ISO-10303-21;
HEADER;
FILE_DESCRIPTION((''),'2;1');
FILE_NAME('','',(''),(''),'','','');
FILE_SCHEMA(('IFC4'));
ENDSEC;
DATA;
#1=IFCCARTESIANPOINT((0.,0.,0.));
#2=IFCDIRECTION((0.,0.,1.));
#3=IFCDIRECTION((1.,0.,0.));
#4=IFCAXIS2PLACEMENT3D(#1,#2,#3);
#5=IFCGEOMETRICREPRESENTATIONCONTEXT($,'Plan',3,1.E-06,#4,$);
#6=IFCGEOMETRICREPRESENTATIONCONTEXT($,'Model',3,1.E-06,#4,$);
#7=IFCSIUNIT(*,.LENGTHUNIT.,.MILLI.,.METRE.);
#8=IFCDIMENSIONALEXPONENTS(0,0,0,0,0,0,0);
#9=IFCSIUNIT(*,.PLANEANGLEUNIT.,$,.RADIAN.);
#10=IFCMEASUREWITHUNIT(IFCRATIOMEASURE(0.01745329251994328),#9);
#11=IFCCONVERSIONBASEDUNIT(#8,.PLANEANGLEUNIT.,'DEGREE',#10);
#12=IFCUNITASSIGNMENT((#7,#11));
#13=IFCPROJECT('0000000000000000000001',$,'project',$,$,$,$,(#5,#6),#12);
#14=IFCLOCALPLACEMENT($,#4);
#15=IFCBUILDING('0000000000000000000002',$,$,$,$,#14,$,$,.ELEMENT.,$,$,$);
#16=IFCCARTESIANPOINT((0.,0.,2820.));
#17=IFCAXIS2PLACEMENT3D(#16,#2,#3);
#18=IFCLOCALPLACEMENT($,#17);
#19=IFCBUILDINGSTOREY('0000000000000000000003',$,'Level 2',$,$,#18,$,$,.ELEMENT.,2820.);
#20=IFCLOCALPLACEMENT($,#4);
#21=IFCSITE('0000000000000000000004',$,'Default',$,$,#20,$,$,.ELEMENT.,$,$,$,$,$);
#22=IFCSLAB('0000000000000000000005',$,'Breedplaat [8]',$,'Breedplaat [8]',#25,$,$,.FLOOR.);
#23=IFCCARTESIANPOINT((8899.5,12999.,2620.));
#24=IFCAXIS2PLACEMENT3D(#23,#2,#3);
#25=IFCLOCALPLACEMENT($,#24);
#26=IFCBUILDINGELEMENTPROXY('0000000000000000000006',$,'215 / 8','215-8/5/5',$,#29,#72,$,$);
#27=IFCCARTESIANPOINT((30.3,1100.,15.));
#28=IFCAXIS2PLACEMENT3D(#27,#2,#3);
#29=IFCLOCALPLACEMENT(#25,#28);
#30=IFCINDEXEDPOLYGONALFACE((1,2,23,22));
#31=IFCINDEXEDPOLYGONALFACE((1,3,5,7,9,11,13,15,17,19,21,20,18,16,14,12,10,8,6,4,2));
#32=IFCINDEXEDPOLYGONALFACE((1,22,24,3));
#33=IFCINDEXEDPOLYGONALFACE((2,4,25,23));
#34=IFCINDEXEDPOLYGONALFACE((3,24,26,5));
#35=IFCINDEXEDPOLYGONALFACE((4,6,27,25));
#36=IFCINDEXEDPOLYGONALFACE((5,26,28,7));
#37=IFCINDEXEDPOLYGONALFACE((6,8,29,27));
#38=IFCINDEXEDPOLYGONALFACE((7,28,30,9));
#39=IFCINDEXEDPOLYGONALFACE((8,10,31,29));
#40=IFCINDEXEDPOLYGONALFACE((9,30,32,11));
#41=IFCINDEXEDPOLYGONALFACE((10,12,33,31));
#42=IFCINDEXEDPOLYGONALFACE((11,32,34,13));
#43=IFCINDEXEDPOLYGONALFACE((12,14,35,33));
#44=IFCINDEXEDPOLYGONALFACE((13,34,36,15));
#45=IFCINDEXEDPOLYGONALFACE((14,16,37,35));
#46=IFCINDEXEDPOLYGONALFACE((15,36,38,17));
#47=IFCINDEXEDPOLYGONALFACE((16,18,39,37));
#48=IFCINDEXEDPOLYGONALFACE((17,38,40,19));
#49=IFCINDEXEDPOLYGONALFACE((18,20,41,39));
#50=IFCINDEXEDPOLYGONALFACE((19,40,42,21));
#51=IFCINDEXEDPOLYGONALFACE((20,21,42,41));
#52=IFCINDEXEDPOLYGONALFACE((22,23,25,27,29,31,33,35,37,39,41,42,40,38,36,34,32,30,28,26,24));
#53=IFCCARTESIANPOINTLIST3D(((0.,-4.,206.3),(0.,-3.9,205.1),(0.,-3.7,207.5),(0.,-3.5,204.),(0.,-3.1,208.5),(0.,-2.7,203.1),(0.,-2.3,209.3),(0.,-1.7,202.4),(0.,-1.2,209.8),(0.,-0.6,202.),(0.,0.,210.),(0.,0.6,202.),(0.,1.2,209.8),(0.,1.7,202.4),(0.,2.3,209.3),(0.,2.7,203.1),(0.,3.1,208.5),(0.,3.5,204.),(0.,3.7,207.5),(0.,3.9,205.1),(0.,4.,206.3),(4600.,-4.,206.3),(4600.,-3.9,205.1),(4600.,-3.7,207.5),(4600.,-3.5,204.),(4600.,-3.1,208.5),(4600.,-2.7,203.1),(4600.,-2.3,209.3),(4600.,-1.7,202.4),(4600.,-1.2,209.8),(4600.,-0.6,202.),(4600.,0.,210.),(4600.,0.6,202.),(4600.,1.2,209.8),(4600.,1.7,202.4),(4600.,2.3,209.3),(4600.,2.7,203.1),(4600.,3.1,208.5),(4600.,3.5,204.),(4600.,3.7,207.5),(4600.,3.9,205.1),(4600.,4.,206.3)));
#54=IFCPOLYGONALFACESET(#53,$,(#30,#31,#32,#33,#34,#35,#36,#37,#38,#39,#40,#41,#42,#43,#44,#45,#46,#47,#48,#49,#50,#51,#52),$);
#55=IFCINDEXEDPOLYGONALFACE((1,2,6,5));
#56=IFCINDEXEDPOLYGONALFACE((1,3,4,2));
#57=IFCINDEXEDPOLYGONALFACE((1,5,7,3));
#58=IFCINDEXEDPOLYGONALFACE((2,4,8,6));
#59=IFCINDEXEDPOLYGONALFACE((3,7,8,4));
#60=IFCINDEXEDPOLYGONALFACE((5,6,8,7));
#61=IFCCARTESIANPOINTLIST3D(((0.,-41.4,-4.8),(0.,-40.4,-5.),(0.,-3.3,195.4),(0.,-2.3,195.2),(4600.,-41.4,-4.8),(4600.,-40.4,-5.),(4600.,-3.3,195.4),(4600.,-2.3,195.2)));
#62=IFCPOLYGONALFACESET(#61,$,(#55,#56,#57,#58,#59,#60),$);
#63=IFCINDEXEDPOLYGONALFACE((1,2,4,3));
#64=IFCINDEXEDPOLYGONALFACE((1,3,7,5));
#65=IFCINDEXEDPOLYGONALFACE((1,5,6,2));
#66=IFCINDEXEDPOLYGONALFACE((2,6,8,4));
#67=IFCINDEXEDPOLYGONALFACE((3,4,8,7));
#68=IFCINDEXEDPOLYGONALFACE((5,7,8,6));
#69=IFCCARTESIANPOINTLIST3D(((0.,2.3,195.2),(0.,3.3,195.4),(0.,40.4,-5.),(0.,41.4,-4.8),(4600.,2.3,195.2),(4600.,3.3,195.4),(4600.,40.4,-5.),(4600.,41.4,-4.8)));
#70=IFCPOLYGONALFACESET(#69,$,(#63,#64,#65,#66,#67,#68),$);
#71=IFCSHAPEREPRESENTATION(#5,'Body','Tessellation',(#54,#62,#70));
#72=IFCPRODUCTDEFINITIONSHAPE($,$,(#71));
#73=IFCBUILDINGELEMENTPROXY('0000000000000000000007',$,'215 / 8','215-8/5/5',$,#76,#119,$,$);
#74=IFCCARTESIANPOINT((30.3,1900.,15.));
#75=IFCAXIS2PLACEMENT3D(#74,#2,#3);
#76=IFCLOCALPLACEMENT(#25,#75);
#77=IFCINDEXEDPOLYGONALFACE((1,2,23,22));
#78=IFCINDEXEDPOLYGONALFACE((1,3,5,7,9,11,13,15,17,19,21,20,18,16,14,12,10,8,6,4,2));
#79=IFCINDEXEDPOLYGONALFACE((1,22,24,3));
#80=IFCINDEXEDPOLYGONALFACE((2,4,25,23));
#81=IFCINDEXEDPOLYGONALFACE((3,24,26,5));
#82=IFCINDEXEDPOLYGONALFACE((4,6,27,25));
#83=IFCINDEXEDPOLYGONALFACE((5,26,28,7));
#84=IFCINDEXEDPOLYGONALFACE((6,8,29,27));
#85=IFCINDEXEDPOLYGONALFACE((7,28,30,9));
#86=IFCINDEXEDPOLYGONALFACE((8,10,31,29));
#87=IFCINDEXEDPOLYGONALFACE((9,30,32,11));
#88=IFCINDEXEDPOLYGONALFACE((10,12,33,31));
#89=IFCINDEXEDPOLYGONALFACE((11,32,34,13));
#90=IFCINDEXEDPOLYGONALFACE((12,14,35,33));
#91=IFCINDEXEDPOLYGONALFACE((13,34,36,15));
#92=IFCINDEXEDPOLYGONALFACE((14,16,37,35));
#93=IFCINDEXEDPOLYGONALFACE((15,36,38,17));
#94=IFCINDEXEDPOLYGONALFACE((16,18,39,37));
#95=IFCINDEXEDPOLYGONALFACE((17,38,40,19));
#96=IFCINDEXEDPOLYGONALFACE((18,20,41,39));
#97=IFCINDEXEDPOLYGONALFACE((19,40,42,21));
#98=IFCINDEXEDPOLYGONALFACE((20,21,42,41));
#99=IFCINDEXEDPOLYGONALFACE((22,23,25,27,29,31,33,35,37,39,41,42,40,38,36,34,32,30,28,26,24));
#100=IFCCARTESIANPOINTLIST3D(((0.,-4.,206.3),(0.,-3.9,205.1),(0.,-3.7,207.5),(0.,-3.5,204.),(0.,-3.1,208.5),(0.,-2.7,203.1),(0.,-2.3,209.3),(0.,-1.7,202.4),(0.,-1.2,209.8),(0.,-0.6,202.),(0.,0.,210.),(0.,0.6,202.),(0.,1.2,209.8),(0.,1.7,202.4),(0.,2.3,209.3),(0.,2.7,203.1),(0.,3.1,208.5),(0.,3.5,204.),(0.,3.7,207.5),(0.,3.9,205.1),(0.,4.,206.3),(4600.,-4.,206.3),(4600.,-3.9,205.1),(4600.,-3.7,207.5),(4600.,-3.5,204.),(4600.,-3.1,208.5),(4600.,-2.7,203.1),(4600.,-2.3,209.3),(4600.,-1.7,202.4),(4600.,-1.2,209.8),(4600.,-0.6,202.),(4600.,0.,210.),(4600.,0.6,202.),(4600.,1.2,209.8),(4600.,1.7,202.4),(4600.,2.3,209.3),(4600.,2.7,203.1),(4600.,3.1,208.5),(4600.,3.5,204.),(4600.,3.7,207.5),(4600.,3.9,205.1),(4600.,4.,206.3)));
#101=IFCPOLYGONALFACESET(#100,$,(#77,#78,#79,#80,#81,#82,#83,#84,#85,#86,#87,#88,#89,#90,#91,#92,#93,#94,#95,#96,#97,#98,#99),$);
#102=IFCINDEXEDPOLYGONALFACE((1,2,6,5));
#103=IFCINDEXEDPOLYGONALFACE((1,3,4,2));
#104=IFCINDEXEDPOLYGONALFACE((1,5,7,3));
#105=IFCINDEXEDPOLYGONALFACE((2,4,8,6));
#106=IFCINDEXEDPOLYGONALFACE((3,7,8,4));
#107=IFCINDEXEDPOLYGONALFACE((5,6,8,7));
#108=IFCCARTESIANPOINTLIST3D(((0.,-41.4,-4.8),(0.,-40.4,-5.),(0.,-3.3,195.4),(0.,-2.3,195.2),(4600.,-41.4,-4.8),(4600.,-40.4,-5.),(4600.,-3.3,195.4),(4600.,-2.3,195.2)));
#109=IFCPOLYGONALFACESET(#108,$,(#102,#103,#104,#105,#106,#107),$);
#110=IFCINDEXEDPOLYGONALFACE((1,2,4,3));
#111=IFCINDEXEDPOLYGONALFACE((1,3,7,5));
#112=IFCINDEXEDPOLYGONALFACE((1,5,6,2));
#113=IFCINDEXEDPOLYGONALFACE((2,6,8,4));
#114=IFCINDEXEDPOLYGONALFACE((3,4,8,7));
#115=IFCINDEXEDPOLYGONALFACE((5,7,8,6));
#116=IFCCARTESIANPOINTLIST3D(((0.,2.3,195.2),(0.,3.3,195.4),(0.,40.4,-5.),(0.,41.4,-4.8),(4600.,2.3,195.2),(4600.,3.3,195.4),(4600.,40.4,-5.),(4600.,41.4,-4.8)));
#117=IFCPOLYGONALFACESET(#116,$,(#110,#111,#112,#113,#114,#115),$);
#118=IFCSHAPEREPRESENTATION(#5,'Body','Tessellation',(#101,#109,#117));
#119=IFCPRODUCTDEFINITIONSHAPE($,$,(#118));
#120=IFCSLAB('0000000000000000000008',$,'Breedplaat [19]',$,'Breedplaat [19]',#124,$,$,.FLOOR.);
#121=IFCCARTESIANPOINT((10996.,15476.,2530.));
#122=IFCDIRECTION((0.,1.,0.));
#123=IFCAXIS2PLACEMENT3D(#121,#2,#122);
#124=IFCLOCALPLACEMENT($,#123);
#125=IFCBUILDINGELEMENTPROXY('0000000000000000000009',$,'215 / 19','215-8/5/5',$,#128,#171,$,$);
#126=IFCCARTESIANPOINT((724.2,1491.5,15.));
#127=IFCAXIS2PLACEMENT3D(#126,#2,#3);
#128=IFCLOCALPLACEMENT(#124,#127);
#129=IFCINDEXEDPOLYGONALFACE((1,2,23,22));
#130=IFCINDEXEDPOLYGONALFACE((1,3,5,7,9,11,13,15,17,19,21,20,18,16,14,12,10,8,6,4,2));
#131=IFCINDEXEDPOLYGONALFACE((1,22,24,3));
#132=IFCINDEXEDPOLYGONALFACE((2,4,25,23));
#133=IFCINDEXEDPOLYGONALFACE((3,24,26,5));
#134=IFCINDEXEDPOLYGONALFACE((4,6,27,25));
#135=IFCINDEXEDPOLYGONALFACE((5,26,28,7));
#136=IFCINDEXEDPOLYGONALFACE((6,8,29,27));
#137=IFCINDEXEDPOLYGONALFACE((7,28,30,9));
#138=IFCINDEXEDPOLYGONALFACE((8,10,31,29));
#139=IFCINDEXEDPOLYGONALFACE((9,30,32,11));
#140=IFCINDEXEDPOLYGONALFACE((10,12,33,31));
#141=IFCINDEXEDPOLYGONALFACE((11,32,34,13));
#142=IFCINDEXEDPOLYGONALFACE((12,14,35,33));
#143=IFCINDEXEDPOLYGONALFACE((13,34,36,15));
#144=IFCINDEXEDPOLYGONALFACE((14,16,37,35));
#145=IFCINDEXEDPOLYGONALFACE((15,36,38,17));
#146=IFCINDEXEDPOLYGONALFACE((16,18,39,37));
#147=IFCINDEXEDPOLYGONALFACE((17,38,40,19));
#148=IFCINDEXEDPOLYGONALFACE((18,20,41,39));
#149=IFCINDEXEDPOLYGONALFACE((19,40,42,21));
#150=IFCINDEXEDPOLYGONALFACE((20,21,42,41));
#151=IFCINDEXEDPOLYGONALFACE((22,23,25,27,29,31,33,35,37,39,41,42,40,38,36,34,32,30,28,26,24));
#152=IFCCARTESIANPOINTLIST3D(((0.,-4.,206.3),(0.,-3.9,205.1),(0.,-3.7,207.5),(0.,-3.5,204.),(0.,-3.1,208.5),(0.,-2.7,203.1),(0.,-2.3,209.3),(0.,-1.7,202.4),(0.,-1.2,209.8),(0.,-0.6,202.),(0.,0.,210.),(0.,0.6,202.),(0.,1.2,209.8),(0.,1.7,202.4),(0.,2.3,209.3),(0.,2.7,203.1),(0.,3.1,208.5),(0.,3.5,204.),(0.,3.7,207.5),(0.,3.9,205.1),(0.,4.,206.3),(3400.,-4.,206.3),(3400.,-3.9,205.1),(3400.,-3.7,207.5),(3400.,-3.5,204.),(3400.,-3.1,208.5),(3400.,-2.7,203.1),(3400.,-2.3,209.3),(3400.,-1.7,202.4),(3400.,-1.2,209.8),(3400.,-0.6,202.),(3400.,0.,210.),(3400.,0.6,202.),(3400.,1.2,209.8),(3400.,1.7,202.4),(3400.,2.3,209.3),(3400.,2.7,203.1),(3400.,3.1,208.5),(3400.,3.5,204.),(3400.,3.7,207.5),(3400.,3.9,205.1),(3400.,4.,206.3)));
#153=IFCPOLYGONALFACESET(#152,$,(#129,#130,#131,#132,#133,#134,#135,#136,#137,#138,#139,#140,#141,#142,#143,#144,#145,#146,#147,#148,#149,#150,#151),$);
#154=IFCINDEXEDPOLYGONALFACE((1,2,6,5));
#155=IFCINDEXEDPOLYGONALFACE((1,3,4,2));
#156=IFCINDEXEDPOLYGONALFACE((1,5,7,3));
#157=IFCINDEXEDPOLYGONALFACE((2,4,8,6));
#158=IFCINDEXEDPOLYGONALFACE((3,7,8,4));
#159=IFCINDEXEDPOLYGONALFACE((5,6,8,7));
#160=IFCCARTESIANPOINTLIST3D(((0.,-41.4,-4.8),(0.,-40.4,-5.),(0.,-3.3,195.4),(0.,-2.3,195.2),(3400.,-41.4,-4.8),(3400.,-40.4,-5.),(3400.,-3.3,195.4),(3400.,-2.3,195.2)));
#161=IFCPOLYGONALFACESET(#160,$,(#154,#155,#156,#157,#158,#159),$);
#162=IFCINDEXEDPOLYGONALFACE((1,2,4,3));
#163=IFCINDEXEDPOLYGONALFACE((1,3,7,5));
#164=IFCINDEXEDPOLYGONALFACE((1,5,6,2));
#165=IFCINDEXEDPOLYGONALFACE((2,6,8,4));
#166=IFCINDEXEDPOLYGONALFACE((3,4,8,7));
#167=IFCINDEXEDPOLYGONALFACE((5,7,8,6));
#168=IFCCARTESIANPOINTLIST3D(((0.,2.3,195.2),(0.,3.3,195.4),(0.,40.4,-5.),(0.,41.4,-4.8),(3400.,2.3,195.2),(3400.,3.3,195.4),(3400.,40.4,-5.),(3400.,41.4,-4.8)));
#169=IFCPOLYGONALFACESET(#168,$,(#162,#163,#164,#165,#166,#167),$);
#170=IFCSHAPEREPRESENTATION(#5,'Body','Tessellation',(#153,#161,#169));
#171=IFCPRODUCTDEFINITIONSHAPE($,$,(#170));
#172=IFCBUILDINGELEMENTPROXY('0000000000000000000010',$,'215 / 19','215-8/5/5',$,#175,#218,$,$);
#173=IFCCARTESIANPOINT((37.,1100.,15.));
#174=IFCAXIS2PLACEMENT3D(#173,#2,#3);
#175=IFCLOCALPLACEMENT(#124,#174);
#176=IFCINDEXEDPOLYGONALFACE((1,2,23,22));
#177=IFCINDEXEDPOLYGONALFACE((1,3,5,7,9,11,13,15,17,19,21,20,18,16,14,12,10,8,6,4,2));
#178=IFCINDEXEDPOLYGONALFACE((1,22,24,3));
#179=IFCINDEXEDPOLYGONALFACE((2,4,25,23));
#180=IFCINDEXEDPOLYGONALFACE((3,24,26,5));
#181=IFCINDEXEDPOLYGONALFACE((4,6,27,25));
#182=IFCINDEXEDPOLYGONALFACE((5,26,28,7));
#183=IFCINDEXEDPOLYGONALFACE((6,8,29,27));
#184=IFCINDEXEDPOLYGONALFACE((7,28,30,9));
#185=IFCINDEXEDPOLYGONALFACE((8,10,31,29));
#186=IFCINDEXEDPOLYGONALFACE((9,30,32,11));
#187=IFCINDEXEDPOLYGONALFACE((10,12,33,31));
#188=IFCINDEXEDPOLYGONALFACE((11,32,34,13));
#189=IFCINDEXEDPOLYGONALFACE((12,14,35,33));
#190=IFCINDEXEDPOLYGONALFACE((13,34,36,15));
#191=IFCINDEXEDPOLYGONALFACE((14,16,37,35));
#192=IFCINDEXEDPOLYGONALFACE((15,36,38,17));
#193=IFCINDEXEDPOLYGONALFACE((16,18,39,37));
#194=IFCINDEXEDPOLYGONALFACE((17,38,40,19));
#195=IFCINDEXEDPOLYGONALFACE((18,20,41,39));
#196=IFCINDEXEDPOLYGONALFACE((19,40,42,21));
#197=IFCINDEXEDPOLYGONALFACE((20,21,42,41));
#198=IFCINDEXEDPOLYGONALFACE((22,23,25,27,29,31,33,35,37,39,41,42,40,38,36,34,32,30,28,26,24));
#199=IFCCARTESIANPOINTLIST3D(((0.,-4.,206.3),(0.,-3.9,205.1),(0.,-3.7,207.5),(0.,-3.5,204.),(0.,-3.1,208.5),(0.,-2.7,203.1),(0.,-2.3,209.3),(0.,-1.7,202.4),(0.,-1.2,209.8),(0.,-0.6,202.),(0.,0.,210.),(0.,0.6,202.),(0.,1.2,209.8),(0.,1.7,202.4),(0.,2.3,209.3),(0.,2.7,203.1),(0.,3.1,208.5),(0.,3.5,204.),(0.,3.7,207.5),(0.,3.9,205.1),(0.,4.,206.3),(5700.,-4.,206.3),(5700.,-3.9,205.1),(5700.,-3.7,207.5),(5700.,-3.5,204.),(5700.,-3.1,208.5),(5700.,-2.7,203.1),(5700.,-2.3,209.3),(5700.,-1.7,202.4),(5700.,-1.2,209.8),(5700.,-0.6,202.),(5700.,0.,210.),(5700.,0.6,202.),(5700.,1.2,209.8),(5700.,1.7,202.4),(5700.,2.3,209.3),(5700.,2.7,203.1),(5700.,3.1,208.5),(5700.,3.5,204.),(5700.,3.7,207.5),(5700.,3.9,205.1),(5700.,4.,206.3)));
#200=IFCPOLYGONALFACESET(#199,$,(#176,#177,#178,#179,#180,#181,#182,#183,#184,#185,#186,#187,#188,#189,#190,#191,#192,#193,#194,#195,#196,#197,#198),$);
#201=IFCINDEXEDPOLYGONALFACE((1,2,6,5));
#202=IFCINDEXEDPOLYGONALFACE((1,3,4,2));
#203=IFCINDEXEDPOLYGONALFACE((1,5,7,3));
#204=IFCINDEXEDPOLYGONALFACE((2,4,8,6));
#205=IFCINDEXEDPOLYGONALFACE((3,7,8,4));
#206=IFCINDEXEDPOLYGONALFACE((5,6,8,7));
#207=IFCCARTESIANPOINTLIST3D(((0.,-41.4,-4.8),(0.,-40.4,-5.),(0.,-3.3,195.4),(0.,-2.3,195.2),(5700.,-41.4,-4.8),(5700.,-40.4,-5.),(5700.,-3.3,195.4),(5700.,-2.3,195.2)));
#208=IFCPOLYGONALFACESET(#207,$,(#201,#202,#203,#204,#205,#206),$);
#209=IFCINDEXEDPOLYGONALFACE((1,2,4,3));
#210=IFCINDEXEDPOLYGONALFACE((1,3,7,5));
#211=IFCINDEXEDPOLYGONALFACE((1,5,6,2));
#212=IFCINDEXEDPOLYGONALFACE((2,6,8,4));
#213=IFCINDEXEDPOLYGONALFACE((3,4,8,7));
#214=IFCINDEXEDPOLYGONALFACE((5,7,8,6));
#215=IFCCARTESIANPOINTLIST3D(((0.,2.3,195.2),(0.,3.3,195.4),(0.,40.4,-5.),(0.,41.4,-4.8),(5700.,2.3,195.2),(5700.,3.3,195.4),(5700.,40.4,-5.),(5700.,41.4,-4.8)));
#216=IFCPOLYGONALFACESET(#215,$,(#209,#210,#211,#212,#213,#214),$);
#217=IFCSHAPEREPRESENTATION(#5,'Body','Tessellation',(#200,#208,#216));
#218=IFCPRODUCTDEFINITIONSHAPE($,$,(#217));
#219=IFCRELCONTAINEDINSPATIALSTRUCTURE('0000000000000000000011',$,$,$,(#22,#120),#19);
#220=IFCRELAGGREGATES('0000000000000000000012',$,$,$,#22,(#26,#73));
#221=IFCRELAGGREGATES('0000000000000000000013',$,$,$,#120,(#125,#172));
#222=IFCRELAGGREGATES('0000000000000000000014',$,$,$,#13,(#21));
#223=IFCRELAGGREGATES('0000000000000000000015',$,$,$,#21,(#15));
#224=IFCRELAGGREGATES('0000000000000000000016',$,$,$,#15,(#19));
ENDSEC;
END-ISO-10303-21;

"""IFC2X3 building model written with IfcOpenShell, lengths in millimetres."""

from ifc_helpers import new_model, entity, si_unit, converted_unit, frame, origin_with_axes, origin_2d_with_axis, place, context, project, spatial, rectangle, circle, extrude, element, aggregate, save


model = new_model("IFC2X3")

# Units and contexts
plan_context = context("Plan", 3, precision=1e-06, world=origin_with_axes())
model_context = context("Model", 3, precision=1e-06, world=origin_with_axes())
ifc_project = project(units=[si_unit("LENGTHUNIT", "METRE", prefix="MILLI"), converted_unit("PLANEANGLEUNIT", "DEGREE", entity("IfcRatioMeasure", 0.01745329251994328), si_unit("PLANEANGLEUNIT", "RADIAN"), dimensions=[0, 0, 0, 0, 0, 0, 0])], contexts=[plan_context, model_context])

# Site, building, storey
site_placement = place(None, origin_with_axes())
site = spatial("IfcSite", under=ifc_project, at=site_placement, Name="Default", CompositionType="ELEMENT")
building_placement = place(None, origin_with_axes())
building = spatial("IfcBuilding", under=site, at=building_placement, CompositionType="ELEMENT")
storey_placement = place(None, frame((0.0, 0.0, 2820.0), z_axis=(0.0, 0.0, 1.0), x_axis=(1.0, 0.0, 0.0)))
storey = spatial("IfcBuildingStorey", under=building, at=storey_placement, Name="Level 2", CompositionType="ELEMENT", Elevation=2820.0)

# Slabs, building element proxies
slab_1_placement = place(None, frame((8899.5, 12999.0, 2620.0), z_axis=(0.0, 0.0, 1.0), x_axis=(1.0, 0.0, 0.0)))
slab_1 = element("IfcSlab", 1, at=slab_1_placement, inside=storey, Name="Breedplaat [8]", ObjectType="Breedplaat [8]", PredefinedType="FLOOR")
proxy_1_placement = place(slab_1_placement, frame((30.3, 1100.0, 15.0), z_axis=(0.0, 0.0, 1.0), x_axis=(1.0, 0.0, 0.0)))
proxy_1 = element("IfcBuildingElementProxy", 2, at=proxy_1_placement, Name="215 / 8", Description="215-8/5/5", context=plan_context, shape_type="SweptSolid", body=[
    extrude(circle(Radius=4.0, at=origin_2d_with_axis()), frame((0.0, 0.0, 206.0), z_axis=(1.0, 0.0, 0.0), x_axis=(0.0, 0.0, 1.0)), (0.0, 0.0, 1.0), 4600.0),
    extrude(rectangle(XDim=203.8, YDim=1.0, at=origin_2d_with_axis()), frame((0.0, -21.9, 95.2), z_axis=(1.0, 0.0, 0.0), x_axis=(0.0, 0.187112, 0.982339)), (0.0, 0.0, 1.0), 4600.0),
    extrude(rectangle(XDim=203.8, YDim=1.0, at=origin_2d_with_axis()), frame((0.0, 21.9, 95.2), z_axis=(1.0, 0.0, 0.0), x_axis=(0.0, -0.187112, 0.982339)), (0.0, 0.0, 1.0), 4600.0),
])
proxy_2_placement = place(slab_1_placement, frame((30.3, 1900.0, 15.0), z_axis=(0.0, 0.0, 1.0), x_axis=(1.0, 0.0, 0.0)))
proxy_2 = element("IfcBuildingElementProxy", 3, at=proxy_2_placement, Name="215 / 8", Description="215-8/5/5", context=plan_context, shape_type="SweptSolid", body=[
    extrude(circle(Radius=4.0, at=origin_2d_with_axis()), frame((0.0, 0.0, 206.0), z_axis=(1.0, 0.0, 0.0), x_axis=(0.0, 0.0, 1.0)), (0.0, 0.0, 1.0), 4600.0),
    extrude(rectangle(XDim=203.8, YDim=1.0, at=origin_2d_with_axis()), frame((0.0, -21.9, 95.2), z_axis=(1.0, 0.0, 0.0), x_axis=(0.0, 0.187112, 0.982339)), (0.0, 0.0, 1.0), 4600.0),
    extrude(rectangle(XDim=203.8, YDim=1.0, at=origin_2d_with_axis()), frame((0.0, 21.9, 95.2), z_axis=(1.0, 0.0, 0.0), x_axis=(0.0, -0.187112, 0.982339)), (0.0, 0.0, 1.0), 4600.0),
])
aggregate(slab_1, [proxy_1, proxy_2])
slab_2_placement = place(None, frame((10996.0, 15476.0, 2530.0), z_axis=(0.0, 0.0, 1.0), x_axis=(0.0, 1.0, 0.0)))
slab_2 = element("IfcSlab", 4, at=slab_2_placement, inside=storey, Name="Breedplaat [19]", ObjectType="Breedplaat [19]", PredefinedType="FLOOR")
proxy_3_placement = place(slab_2_placement, frame((724.2, 1491.5, 15.0), z_axis=(0.0, 0.0, 1.0), x_axis=(1.0, 0.0, 0.0)))
proxy_3 = element("IfcBuildingElementProxy", 5, at=proxy_3_placement, Name="215 / 19", Description="215-8/5/5", context=plan_context, shape_type="SweptSolid", body=[
    extrude(circle(Radius=4.0, at=origin_2d_with_axis()), frame((0.0, 0.0, 206.0), z_axis=(1.0, 0.0, 0.0), x_axis=(0.0, 0.0, 1.0)), (0.0, 0.0, 1.0), 3400.0),
    extrude(rectangle(XDim=203.8, YDim=1.0, at=origin_2d_with_axis()), frame((0.0, -21.9, 95.2), z_axis=(1.0, 0.0, 0.0), x_axis=(0.0, 0.187112, 0.982339)), (0.0, 0.0, 1.0), 3400.0),
    extrude(rectangle(XDim=203.8, YDim=1.0, at=origin_2d_with_axis()), frame((0.0, 21.9, 95.2), z_axis=(1.0, 0.0, 0.0), x_axis=(0.0, -0.187112, 0.982339)), (0.0, 0.0, 1.0), 3400.0),
])
proxy_4_placement = place(slab_2_placement, frame((37.0, 1100.0, 15.0), z_axis=(0.0, 0.0, 1.0), x_axis=(1.0, 0.0, 0.0)))
proxy_4 = element("IfcBuildingElementProxy", 6, at=proxy_4_placement, Name="215 / 19", Description="215-8/5/5", context=plan_context, shape_type="SweptSolid", body=[
    extrude(circle(Radius=4.0, at=origin_2d_with_axis()), frame((0.0, 0.0, 206.0), z_axis=(1.0, 0.0, 0.0), x_axis=(0.0, 0.0, 1.0)), (0.0, 0.0, 1.0), 5700.0),
    extrude(rectangle(XDim=203.8, YDim=1.0, at=origin_2d_with_axis()), frame((0.0, -21.9, 95.2), z_axis=(1.0, 0.0, 0.0), x_axis=(0.0, 0.187112, 0.982339)), (0.0, 0.0, 1.0), 5700.0),
    extrude(rectangle(XDim=203.8, YDim=1.0, at=origin_2d_with_axis()), frame((0.0, 21.9, 95.2), z_axis=(1.0, 0.0, 0.0), x_axis=(0.0, -0.187112, 0.982339)), (0.0, 0.0, 1.0), 5700.0),
])
aggregate(slab_2, [proxy_3, proxy_4])

save(model, "model.ifc")
